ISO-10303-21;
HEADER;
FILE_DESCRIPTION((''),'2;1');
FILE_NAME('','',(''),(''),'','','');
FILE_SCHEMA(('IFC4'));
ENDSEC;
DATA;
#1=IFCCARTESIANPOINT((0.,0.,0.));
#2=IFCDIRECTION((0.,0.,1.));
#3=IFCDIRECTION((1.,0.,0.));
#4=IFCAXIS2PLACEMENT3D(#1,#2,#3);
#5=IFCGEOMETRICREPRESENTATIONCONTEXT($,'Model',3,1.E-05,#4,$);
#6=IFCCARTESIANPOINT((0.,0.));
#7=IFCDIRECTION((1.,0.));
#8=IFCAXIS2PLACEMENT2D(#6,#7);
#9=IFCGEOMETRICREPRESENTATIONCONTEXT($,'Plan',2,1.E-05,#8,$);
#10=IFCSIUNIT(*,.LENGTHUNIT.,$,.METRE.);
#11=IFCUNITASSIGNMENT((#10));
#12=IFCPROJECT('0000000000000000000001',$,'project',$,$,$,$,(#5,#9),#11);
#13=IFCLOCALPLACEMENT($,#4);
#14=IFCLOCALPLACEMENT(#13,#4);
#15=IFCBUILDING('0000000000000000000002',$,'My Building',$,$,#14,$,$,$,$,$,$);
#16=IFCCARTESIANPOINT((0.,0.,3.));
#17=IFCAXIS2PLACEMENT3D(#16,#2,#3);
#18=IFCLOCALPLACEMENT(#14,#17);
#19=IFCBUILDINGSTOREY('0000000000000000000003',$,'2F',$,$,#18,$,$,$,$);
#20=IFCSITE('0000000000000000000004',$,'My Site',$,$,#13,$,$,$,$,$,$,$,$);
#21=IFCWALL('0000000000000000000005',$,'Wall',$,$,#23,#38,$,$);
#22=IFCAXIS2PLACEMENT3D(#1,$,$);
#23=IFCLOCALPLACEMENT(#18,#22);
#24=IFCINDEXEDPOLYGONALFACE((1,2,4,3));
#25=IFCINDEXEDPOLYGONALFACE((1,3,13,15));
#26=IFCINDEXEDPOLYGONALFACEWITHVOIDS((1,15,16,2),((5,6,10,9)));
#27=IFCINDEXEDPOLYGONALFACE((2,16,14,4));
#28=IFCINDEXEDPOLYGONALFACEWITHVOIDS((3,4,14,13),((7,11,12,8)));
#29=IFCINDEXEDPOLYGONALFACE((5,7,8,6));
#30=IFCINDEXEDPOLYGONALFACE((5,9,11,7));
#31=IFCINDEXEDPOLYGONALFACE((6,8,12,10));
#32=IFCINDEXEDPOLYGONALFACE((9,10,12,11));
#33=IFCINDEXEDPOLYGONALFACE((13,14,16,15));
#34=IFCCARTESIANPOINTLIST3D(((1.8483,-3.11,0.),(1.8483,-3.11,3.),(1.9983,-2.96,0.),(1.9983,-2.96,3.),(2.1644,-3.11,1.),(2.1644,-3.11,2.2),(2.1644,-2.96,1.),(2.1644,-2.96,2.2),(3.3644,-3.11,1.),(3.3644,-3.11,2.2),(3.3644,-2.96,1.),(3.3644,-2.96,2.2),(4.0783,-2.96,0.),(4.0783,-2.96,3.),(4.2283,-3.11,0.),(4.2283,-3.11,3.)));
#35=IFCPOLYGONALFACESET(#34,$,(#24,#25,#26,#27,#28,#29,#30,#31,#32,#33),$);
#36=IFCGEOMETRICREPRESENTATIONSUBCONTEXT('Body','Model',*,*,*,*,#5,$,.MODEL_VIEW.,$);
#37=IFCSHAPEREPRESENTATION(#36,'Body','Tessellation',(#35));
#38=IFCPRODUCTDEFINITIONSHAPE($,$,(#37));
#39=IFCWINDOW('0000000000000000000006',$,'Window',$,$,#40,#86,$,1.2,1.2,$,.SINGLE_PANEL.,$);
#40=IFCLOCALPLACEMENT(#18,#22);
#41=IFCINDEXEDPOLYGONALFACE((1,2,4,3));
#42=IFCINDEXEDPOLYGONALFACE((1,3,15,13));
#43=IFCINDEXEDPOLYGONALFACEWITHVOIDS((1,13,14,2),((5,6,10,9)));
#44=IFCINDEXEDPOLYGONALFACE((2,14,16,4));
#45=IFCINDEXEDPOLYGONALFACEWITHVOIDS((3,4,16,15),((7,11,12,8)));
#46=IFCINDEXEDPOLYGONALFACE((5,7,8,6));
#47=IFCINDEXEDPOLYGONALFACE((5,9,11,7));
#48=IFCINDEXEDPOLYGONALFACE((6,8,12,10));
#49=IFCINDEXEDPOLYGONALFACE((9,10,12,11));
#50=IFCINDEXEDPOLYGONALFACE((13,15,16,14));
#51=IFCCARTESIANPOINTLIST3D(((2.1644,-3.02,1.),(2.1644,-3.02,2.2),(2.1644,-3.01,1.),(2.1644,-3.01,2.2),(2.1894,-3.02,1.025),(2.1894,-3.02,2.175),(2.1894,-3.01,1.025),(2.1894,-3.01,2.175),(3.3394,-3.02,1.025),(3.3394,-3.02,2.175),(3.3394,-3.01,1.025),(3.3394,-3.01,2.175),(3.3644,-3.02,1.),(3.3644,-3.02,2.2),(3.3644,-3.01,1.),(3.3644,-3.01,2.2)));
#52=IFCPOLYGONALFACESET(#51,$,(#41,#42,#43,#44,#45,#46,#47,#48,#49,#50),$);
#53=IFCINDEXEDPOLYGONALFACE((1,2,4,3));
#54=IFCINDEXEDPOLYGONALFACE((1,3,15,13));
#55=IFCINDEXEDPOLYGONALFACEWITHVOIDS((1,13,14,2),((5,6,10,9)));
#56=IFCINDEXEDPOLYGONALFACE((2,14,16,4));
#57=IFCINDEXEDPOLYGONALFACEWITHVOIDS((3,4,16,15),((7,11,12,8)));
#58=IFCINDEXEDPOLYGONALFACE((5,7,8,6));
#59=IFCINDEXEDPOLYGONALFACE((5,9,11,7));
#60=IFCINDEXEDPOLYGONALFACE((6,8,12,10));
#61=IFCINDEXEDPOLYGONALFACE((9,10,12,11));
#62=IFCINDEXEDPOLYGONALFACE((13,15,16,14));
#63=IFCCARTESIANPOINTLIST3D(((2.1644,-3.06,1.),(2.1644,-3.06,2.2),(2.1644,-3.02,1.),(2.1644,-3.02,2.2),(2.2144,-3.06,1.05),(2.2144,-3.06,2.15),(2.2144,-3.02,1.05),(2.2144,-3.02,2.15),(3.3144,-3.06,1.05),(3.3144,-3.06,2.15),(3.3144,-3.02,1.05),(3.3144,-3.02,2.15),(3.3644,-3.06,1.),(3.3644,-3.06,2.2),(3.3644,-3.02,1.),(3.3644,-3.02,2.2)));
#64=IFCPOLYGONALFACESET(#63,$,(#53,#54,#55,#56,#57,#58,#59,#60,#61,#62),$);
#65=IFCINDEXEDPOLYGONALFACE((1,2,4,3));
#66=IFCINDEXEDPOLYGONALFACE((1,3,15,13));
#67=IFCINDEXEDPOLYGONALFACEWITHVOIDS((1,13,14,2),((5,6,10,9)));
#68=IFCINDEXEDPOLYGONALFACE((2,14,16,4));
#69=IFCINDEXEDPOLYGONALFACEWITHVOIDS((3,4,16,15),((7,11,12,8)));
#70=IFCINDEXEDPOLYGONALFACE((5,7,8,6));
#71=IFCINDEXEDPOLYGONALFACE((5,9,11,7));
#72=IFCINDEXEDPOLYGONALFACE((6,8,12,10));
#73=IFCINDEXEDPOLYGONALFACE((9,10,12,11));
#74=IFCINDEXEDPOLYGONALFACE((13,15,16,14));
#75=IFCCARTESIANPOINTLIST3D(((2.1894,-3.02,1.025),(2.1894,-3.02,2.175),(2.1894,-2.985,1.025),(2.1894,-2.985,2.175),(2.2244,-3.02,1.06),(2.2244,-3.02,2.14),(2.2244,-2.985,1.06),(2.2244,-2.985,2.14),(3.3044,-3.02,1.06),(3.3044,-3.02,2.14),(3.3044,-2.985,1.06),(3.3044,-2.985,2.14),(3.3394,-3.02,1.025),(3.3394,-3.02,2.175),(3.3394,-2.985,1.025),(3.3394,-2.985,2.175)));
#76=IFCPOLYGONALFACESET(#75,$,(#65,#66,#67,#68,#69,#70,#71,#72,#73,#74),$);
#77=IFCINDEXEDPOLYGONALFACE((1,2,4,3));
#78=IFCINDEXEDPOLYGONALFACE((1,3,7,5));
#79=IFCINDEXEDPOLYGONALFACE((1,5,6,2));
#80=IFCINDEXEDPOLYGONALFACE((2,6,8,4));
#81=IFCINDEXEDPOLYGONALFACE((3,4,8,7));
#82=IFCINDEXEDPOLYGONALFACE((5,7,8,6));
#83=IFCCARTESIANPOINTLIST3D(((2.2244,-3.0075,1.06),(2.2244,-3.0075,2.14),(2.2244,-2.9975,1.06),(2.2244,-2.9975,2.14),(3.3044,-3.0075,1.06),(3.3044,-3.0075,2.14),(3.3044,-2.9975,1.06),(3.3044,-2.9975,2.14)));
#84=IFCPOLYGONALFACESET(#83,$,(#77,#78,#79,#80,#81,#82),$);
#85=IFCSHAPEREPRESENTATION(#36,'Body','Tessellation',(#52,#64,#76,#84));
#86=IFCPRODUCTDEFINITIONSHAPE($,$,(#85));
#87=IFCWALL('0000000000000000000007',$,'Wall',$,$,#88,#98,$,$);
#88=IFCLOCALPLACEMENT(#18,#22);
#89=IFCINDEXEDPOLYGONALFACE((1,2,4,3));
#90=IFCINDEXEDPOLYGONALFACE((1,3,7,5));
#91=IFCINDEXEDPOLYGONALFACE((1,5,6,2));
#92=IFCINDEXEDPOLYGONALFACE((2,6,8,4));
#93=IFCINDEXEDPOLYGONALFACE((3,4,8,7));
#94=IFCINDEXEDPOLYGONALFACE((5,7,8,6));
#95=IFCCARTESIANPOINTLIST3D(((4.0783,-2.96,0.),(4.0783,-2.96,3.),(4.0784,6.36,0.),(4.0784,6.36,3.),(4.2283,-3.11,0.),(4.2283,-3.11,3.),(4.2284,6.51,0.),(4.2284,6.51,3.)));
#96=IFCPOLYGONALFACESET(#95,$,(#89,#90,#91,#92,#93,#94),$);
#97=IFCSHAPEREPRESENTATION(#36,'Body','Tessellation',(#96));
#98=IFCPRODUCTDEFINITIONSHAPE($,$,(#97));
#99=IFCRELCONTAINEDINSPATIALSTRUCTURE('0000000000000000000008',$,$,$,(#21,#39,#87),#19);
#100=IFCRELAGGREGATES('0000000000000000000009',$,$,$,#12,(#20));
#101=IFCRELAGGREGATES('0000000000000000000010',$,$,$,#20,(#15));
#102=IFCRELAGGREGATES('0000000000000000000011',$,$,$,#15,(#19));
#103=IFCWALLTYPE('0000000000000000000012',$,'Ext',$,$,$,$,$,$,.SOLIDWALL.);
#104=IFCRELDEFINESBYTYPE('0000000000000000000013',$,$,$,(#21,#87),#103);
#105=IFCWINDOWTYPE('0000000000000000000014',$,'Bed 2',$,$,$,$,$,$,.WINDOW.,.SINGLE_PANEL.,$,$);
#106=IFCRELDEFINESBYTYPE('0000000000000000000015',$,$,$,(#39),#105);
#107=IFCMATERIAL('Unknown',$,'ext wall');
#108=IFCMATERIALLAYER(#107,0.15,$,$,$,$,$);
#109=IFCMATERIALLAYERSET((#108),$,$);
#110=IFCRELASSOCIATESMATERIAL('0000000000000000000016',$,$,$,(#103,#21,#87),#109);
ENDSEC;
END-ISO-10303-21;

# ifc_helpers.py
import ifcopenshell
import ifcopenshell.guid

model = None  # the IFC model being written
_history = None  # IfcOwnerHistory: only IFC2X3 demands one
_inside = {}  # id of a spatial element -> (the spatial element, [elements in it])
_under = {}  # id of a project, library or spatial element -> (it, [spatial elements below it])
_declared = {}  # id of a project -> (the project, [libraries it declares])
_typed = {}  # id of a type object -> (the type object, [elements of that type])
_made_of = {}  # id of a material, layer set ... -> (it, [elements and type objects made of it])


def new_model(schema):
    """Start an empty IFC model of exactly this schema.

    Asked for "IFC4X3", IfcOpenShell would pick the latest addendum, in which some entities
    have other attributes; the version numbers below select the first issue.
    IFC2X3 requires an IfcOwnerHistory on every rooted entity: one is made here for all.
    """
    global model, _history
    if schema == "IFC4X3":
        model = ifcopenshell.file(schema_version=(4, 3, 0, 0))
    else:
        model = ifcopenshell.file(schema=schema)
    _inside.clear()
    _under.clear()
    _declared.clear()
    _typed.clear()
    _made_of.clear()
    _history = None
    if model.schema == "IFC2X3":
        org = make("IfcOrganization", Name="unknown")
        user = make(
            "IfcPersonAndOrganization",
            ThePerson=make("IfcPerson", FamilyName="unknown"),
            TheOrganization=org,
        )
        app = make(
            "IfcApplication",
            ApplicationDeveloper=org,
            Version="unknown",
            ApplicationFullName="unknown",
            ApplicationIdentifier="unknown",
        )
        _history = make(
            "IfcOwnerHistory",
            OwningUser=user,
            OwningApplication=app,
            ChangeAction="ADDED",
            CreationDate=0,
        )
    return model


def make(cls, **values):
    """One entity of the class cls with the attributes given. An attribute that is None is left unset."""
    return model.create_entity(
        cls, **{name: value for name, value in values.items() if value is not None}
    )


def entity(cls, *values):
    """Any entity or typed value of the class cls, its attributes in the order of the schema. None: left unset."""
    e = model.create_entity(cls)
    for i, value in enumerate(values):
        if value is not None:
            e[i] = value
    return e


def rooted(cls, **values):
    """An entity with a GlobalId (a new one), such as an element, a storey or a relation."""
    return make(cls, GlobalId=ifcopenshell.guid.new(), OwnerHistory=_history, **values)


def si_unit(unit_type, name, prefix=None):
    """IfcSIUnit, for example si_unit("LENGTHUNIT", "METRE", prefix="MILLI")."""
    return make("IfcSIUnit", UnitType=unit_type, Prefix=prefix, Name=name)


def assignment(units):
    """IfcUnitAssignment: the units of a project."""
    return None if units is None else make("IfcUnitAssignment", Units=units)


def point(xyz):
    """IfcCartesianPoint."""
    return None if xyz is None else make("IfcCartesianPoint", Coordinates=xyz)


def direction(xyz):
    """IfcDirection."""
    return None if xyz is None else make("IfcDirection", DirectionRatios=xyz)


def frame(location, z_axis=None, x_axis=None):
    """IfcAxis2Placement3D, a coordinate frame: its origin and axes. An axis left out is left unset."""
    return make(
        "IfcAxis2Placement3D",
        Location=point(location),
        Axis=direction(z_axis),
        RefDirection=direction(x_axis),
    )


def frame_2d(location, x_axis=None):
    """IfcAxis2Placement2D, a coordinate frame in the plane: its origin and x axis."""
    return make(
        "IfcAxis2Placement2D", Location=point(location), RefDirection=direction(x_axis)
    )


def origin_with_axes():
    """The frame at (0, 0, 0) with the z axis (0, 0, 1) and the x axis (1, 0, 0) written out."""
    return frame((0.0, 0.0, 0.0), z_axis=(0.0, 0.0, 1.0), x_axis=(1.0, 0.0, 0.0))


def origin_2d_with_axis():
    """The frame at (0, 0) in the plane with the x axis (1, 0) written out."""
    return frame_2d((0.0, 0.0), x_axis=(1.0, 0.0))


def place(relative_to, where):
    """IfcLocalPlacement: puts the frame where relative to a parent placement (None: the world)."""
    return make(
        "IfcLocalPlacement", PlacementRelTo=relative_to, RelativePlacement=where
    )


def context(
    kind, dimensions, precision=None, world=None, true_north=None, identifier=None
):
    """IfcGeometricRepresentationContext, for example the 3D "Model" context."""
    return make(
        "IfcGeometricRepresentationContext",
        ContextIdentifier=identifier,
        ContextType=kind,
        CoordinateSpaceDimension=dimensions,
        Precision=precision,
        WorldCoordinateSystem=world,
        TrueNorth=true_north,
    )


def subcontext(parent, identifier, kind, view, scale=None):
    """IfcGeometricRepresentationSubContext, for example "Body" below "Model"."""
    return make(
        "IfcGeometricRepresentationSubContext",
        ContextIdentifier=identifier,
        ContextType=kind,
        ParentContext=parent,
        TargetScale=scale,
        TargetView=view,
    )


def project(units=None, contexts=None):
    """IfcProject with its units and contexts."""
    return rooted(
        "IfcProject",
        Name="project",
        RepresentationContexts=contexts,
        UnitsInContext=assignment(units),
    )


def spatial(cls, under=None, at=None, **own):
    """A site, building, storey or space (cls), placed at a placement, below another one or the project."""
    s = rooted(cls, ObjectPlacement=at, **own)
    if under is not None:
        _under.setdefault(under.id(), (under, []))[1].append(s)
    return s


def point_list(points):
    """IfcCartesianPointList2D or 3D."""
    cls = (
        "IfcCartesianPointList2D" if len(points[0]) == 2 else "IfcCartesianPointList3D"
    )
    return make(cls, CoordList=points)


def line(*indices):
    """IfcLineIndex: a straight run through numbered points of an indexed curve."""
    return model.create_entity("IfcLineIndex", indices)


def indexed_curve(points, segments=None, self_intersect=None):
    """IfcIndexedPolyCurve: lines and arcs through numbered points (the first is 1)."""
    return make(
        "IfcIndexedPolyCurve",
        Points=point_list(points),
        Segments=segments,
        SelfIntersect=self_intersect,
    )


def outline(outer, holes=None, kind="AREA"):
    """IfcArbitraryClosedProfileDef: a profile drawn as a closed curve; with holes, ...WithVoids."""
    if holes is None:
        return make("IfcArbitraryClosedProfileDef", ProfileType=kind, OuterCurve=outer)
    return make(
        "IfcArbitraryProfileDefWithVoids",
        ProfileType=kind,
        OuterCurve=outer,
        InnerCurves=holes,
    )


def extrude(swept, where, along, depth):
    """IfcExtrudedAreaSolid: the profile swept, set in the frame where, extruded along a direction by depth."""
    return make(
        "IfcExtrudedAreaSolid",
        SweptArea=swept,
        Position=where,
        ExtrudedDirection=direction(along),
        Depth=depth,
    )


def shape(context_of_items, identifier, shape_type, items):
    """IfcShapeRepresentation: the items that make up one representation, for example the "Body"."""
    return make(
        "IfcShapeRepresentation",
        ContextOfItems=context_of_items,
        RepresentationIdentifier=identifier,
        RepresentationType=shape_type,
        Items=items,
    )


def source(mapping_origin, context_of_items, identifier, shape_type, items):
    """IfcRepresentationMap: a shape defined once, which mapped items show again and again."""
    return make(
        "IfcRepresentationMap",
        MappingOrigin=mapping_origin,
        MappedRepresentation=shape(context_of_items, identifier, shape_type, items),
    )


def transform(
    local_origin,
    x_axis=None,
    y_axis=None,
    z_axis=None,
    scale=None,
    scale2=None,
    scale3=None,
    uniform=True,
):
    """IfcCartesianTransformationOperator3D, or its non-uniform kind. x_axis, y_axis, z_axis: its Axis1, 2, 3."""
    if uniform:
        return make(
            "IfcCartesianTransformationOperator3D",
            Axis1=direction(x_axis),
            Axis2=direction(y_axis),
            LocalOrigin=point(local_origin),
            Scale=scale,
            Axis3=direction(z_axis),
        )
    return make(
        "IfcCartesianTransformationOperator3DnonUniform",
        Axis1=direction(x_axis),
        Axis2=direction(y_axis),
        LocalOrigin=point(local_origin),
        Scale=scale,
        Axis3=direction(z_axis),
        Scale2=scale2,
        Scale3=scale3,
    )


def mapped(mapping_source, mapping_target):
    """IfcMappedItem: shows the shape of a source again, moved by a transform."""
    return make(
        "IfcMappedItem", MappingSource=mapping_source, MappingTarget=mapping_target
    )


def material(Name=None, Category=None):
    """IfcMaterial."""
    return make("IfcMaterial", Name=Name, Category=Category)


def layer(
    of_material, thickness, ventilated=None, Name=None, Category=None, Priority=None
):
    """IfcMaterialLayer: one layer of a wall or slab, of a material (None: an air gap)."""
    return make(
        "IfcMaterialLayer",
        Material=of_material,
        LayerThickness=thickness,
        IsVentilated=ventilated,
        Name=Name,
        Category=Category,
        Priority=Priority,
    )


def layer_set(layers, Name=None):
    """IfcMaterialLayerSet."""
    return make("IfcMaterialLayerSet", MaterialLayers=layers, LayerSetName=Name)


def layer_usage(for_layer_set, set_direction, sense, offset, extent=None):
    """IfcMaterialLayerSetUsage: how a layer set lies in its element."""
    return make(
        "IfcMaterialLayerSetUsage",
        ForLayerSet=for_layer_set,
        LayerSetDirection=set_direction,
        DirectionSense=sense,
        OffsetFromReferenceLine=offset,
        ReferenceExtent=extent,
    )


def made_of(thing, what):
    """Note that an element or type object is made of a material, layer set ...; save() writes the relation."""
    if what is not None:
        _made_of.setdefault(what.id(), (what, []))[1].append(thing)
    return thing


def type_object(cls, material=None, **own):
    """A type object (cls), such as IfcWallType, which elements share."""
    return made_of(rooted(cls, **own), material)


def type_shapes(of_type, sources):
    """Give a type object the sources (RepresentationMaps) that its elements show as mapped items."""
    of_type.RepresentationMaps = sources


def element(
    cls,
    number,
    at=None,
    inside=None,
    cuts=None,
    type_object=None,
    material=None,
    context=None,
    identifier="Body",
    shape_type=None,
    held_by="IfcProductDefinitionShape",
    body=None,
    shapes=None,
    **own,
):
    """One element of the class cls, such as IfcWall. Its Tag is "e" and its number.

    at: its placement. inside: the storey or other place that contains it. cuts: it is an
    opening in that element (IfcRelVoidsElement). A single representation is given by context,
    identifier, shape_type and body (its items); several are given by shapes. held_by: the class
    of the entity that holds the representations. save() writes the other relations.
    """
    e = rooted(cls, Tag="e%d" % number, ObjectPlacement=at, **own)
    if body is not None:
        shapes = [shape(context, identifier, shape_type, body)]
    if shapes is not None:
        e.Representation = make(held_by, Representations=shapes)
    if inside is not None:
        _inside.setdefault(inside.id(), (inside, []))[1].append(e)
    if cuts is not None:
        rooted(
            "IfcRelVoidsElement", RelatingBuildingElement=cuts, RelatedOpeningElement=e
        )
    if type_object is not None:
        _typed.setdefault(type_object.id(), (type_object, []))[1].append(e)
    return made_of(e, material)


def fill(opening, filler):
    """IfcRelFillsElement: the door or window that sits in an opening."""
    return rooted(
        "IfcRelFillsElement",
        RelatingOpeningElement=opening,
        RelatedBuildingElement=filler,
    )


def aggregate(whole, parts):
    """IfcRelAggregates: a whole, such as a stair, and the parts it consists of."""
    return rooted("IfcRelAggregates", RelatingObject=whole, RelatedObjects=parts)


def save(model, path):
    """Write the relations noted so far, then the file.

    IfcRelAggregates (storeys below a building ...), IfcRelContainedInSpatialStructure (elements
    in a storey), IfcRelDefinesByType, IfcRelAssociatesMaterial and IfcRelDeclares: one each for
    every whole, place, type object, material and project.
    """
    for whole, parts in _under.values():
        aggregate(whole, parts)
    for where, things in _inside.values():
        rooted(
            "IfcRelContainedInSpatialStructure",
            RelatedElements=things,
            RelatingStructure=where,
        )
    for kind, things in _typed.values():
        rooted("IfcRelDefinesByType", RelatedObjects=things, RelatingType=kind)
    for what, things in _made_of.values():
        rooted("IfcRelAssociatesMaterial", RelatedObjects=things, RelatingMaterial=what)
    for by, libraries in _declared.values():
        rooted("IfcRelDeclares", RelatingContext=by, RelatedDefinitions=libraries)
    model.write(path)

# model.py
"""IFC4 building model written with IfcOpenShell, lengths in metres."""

from ifc_helpers import new_model, entity, si_unit, frame, origin_with_axes, origin_2d_with_axis, place, context, subcontext, project, spatial, line, indexed_curve, outline, extrude, shape, source, transform, mapped, material, layer, layer_set, layer_usage, type_object, type_shapes, element, fill, save


model = new_model("IFC4")

# Units and contexts
model_context = context("Model", 3, precision=1e-05, world=origin_with_axes())
plan_context = context("Plan", 2, precision=1e-05, world=origin_2d_with_axis())
body_context_1 = subcontext(model_context, "Body", "Model", "MODEL_VIEW")
body_context_2 = subcontext(plan_context, "Body", "Plan", "PLAN_VIEW")
ifc_project = project(units=[si_unit("LENGTHUNIT", "METRE")], contexts=[model_context, plan_context])

# Site, building, storey
site_placement = place(None, origin_with_axes())
site = spatial("IfcSite", under=ifc_project, at=site_placement, Name="My Site")
building_placement = place(site_placement, origin_with_axes())
building = spatial("IfcBuilding", under=site, at=building_placement, Name="My Building")
storey_placement = place(building_placement, frame((0.0, 0.0, 3.0), z_axis=(0.0, 0.0, 1.0), x_axis=(1.0, 0.0, 0.0)))
storey = spatial("IfcBuildingStorey", under=building, at=storey_placement, Name="2F")

# Shared definitions
ifc_material = material(Name="Unknown", Category="ext wall")

# Shared definitions
ifc_layer_1 = layer(ifc_material, 0.15)
ifc_layer_set_1 = layer_set([ifc_layer_1])
wall_type_1 = type_object("IfcWallType", Name="Ext", PredefinedType="SOLIDWALL", material=ifc_layer_set_1)

# Wall, opening, window
ifc_layer_usage_1 = layer_usage(ifc_layer_set_1, "AXIS2", "POSITIVE", 0.0)
wall_1_placement = place(storey_placement, frame((1.8483, -3.11, 0.0), z_axis=(0.0, 0.0, 1.0), x_axis=(1.0, 0.0, 0.0)))
wall_1 = element("IfcWall", 1, at=wall_1_placement, inside=storey, type_object=wall_type_1, material=ifc_layer_usage_1, Name="Wall", context=body_context_1, shape_type="SweptSolid", body=[
    extrude(outline(indexed_curve([(0.0, 0.0), (0.15, 0.15), (2.23, 0.15), (2.38, 0.0)], segments=[line(1, 2, 3, 4, 1)])), origin_with_axes(), (0.0, 0.0, 1.0), 3.0),
])
shared_shape_1 = source(origin_with_axes(), body_context_1, "Body", "SweptSolid", [
    extrude(outline(indexed_curve([(0.0, 0.0), (1.2, 0.0), (1.2, 1.2), (0.0, 1.2)], segments=[line(1, 2, 3, 4, 1)])), frame((0.0, -0.6, 0.0), z_axis=(0.0, -1.0, 0.0), x_axis=(1.0, 0.0, 0.0)), (0.0, 0.0, -1.0), 1.2),
])
opening_1_placement = place(wall_1_placement, frame((0.316, 0.0, 1.0), z_axis=(0.0, 0.0, 1.0), x_axis=(1.0, 0.0, 0.0)))
opening_1 = element("IfcOpeningElement", 2, at=opening_1_placement, cuts=wall_1, PredefinedType="OPENING", context=body_context_1, shape_type="MappedRepresentation", body=[
    mapped(shared_shape_1, transform((0.0, 0.0, 0.0), x_axis=(1.0, 0.0, 0.0), y_axis=(0.0, 1.0, 0.0), z_axis=(0.0, 0.0, 1.0), scale=1.0)),
])
window_type = type_object("IfcWindowType", Name="Bed 2", PartitioningType="SINGLE_PANEL", PredefinedType="WINDOW")
shared_shape_2 = source(origin_with_axes(), body_context_1, "Body", "SweptSolid", [
    extrude(outline(indexed_curve([(0.0, 0.0), (1.2, 0.0), (1.2, 1.2), (0.0, 1.2)], segments=[line(1, 2, 3, 4, 1)]), holes=[indexed_curve([(0.025, 0.025), (1.175, 0.025), (1.175, 1.175), (0.025, 1.175)], segments=[line(1, 2, 3, 4, 1)])]), frame((0.0, 0.09, 0.0), z_axis=(0.0, -1.0, 0.0), x_axis=(1.0, 0.0, 0.0)), (0.0, 0.0, -1.0), 0.01),
    extrude(outline(indexed_curve([(0.0, 0.0), (1.2, 0.0), (1.2, 1.2), (0.0, 1.2)], segments=[line(1, 2, 3, 4, 1)]), holes=[indexed_curve([(0.05, 0.05), (1.15, 0.05), (1.15, 1.15), (0.05, 1.15)], segments=[line(1, 2, 3, 4, 1)])]), frame((0.0, 0.05, 0.0), z_axis=(0.0, -1.0, 0.0), x_axis=(1.0, 0.0, 0.0)), (0.0, 0.0, -1.0), 0.04),
    extrude(outline(indexed_curve([(0.0, 0.0), (1.15, 0.0), (1.15, 1.15), (0.0, 1.15)], segments=[line(1, 2, 3, 4, 1)]), holes=[indexed_curve([(0.035, 0.035), (1.115, 0.035), (1.115, 1.115), (0.035, 1.115)], segments=[line(1, 2, 3, 4, 1)])]), frame((0.025, 0.09, 0.025), z_axis=(0.0, -1.0, 0.0), x_axis=(1.0, 0.0, 0.0)), (0.0, 0.0, -1.0), 0.035),
    extrude(outline(indexed_curve([(0.035, 0.035), (1.115, 0.035), (1.115, 1.115), (0.035, 1.115)], segments=[line(1, 2, 3, 4, 1)])), frame((0.025, 0.1025, 0.025), z_axis=(0.0, -1.0, 0.0), x_axis=(1.0, 0.0, 0.0)), (0.0, 0.0, -1.0), 0.01),
])
shared_shape_3 = source(origin_with_axes(), body_context_2, "Body", "Curve2D", [
    entity("IfcIndexedPolyCurve", entity("IfcCartesianPointList2D", [[0.05, 0.05], [1.15, 0.05]])),
    entity("IfcIndexedPolyCurve", entity("IfcCartesianPointList2D", [[0.0, 0.1], [0.025, 0.1], [0.025, 0.09], [0.05, 0.09], [0.05, 0.05], [0.0, 0.05]]), [entity("IfcLineIndex", [1, 2, 3, 4, 5, 6, 1])]),
    entity("IfcIndexedPolyCurve", entity("IfcCartesianPointList2D", [[1.2, 0.1], [1.175, 0.1], [1.175, 0.09], [1.15, 0.09], [1.15, 0.05], [1.2, 0.05]]), [entity("IfcLineIndex", [1, 2, 3, 4, 5, 6, 1])]),
    entity("IfcIndexedPolyCurve", entity("IfcCartesianPointList2D", [[0.025, 0.09], [0.06, 0.09], [0.06, 0.125], [0.025, 0.125]]), [entity("IfcLineIndex", [1, 2, 3, 4, 1])]),
    entity("IfcIndexedPolyCurve", entity("IfcCartesianPointList2D", [[1.175, 0.09], [1.14, 0.09], [1.14, 0.125], [1.175, 0.125]]), [entity("IfcLineIndex", [1, 2, 3, 4, 1])]),
    entity("IfcIndexedPolyCurve", entity("IfcCartesianPointList2D", [[0.06, 0.09], [1.14, 0.09]])),
    entity("IfcIndexedPolyCurve", entity("IfcCartesianPointList2D", [[0.06, 0.125], [1.14, 0.125]])),
    entity("IfcIndexedPolyCurve", entity("IfcCartesianPointList2D", [[0.06, 0.1075], [1.14, 0.1075]])),
])
type_shapes(window_type, [shared_shape_2, shared_shape_3])
window_placement = place(opening_1_placement, frame((0.0, 0.0, 0.0), z_axis=(0.0, 0.0, 1.0), x_axis=(1.0, 0.0, 0.0)))
window = element("IfcWindow", 3, at=window_placement, inside=storey, type_object=window_type, Name="Window", OverallHeight=1.2, OverallWidth=1.2, PartitioningType="SINGLE_PANEL", shapes=[
    shape(body_context_1, "Body", "MappedRepresentation", [mapped(shared_shape_2, transform((0.0, 0.0, 0.0), x_axis=(1.0, 0.0, 0.0), y_axis=(0.0, 1.0, 0.0), z_axis=(0.0, 0.0, 1.0), scale=1.0))]),
    shape(body_context_2, "Body", "MappedRepresentation", [mapped(shared_shape_3, transform((0.0, 0.0, 0.0), x_axis=(1.0, 0.0, 0.0), y_axis=(0.0, 1.0, 0.0), z_axis=(0.0, 0.0, 1.0), scale=1.0))]),
])
fill(opening_1, window)

# Wall
ifc_layer_usage_2 = layer_usage(ifc_layer_set_1, "AXIS2", "POSITIVE", 0.0)
wall_2_placement = place(storey_placement, frame((4.2283, -3.11, 0.0), z_axis=(0.0, 0.0, 1.0), x_axis=(0.0, 1.0, 0.0)))
element("IfcWall", 4, at=wall_2_placement, inside=storey, type_object=wall_type_1, material=ifc_layer_usage_2, Name="Wall", context=body_context_1, shape_type="SweptSolid", body=[
    extrude(outline(indexed_curve([(0.0, 0.0), (0.15, 0.15), (9.47, 0.15), (9.62, 0.0)], segments=[line(1, 2, 3, 4, 1)])), origin_with_axes(), (0.0, 0.0, 1.0), 3.0),
])

save(model, "model.ifc")
